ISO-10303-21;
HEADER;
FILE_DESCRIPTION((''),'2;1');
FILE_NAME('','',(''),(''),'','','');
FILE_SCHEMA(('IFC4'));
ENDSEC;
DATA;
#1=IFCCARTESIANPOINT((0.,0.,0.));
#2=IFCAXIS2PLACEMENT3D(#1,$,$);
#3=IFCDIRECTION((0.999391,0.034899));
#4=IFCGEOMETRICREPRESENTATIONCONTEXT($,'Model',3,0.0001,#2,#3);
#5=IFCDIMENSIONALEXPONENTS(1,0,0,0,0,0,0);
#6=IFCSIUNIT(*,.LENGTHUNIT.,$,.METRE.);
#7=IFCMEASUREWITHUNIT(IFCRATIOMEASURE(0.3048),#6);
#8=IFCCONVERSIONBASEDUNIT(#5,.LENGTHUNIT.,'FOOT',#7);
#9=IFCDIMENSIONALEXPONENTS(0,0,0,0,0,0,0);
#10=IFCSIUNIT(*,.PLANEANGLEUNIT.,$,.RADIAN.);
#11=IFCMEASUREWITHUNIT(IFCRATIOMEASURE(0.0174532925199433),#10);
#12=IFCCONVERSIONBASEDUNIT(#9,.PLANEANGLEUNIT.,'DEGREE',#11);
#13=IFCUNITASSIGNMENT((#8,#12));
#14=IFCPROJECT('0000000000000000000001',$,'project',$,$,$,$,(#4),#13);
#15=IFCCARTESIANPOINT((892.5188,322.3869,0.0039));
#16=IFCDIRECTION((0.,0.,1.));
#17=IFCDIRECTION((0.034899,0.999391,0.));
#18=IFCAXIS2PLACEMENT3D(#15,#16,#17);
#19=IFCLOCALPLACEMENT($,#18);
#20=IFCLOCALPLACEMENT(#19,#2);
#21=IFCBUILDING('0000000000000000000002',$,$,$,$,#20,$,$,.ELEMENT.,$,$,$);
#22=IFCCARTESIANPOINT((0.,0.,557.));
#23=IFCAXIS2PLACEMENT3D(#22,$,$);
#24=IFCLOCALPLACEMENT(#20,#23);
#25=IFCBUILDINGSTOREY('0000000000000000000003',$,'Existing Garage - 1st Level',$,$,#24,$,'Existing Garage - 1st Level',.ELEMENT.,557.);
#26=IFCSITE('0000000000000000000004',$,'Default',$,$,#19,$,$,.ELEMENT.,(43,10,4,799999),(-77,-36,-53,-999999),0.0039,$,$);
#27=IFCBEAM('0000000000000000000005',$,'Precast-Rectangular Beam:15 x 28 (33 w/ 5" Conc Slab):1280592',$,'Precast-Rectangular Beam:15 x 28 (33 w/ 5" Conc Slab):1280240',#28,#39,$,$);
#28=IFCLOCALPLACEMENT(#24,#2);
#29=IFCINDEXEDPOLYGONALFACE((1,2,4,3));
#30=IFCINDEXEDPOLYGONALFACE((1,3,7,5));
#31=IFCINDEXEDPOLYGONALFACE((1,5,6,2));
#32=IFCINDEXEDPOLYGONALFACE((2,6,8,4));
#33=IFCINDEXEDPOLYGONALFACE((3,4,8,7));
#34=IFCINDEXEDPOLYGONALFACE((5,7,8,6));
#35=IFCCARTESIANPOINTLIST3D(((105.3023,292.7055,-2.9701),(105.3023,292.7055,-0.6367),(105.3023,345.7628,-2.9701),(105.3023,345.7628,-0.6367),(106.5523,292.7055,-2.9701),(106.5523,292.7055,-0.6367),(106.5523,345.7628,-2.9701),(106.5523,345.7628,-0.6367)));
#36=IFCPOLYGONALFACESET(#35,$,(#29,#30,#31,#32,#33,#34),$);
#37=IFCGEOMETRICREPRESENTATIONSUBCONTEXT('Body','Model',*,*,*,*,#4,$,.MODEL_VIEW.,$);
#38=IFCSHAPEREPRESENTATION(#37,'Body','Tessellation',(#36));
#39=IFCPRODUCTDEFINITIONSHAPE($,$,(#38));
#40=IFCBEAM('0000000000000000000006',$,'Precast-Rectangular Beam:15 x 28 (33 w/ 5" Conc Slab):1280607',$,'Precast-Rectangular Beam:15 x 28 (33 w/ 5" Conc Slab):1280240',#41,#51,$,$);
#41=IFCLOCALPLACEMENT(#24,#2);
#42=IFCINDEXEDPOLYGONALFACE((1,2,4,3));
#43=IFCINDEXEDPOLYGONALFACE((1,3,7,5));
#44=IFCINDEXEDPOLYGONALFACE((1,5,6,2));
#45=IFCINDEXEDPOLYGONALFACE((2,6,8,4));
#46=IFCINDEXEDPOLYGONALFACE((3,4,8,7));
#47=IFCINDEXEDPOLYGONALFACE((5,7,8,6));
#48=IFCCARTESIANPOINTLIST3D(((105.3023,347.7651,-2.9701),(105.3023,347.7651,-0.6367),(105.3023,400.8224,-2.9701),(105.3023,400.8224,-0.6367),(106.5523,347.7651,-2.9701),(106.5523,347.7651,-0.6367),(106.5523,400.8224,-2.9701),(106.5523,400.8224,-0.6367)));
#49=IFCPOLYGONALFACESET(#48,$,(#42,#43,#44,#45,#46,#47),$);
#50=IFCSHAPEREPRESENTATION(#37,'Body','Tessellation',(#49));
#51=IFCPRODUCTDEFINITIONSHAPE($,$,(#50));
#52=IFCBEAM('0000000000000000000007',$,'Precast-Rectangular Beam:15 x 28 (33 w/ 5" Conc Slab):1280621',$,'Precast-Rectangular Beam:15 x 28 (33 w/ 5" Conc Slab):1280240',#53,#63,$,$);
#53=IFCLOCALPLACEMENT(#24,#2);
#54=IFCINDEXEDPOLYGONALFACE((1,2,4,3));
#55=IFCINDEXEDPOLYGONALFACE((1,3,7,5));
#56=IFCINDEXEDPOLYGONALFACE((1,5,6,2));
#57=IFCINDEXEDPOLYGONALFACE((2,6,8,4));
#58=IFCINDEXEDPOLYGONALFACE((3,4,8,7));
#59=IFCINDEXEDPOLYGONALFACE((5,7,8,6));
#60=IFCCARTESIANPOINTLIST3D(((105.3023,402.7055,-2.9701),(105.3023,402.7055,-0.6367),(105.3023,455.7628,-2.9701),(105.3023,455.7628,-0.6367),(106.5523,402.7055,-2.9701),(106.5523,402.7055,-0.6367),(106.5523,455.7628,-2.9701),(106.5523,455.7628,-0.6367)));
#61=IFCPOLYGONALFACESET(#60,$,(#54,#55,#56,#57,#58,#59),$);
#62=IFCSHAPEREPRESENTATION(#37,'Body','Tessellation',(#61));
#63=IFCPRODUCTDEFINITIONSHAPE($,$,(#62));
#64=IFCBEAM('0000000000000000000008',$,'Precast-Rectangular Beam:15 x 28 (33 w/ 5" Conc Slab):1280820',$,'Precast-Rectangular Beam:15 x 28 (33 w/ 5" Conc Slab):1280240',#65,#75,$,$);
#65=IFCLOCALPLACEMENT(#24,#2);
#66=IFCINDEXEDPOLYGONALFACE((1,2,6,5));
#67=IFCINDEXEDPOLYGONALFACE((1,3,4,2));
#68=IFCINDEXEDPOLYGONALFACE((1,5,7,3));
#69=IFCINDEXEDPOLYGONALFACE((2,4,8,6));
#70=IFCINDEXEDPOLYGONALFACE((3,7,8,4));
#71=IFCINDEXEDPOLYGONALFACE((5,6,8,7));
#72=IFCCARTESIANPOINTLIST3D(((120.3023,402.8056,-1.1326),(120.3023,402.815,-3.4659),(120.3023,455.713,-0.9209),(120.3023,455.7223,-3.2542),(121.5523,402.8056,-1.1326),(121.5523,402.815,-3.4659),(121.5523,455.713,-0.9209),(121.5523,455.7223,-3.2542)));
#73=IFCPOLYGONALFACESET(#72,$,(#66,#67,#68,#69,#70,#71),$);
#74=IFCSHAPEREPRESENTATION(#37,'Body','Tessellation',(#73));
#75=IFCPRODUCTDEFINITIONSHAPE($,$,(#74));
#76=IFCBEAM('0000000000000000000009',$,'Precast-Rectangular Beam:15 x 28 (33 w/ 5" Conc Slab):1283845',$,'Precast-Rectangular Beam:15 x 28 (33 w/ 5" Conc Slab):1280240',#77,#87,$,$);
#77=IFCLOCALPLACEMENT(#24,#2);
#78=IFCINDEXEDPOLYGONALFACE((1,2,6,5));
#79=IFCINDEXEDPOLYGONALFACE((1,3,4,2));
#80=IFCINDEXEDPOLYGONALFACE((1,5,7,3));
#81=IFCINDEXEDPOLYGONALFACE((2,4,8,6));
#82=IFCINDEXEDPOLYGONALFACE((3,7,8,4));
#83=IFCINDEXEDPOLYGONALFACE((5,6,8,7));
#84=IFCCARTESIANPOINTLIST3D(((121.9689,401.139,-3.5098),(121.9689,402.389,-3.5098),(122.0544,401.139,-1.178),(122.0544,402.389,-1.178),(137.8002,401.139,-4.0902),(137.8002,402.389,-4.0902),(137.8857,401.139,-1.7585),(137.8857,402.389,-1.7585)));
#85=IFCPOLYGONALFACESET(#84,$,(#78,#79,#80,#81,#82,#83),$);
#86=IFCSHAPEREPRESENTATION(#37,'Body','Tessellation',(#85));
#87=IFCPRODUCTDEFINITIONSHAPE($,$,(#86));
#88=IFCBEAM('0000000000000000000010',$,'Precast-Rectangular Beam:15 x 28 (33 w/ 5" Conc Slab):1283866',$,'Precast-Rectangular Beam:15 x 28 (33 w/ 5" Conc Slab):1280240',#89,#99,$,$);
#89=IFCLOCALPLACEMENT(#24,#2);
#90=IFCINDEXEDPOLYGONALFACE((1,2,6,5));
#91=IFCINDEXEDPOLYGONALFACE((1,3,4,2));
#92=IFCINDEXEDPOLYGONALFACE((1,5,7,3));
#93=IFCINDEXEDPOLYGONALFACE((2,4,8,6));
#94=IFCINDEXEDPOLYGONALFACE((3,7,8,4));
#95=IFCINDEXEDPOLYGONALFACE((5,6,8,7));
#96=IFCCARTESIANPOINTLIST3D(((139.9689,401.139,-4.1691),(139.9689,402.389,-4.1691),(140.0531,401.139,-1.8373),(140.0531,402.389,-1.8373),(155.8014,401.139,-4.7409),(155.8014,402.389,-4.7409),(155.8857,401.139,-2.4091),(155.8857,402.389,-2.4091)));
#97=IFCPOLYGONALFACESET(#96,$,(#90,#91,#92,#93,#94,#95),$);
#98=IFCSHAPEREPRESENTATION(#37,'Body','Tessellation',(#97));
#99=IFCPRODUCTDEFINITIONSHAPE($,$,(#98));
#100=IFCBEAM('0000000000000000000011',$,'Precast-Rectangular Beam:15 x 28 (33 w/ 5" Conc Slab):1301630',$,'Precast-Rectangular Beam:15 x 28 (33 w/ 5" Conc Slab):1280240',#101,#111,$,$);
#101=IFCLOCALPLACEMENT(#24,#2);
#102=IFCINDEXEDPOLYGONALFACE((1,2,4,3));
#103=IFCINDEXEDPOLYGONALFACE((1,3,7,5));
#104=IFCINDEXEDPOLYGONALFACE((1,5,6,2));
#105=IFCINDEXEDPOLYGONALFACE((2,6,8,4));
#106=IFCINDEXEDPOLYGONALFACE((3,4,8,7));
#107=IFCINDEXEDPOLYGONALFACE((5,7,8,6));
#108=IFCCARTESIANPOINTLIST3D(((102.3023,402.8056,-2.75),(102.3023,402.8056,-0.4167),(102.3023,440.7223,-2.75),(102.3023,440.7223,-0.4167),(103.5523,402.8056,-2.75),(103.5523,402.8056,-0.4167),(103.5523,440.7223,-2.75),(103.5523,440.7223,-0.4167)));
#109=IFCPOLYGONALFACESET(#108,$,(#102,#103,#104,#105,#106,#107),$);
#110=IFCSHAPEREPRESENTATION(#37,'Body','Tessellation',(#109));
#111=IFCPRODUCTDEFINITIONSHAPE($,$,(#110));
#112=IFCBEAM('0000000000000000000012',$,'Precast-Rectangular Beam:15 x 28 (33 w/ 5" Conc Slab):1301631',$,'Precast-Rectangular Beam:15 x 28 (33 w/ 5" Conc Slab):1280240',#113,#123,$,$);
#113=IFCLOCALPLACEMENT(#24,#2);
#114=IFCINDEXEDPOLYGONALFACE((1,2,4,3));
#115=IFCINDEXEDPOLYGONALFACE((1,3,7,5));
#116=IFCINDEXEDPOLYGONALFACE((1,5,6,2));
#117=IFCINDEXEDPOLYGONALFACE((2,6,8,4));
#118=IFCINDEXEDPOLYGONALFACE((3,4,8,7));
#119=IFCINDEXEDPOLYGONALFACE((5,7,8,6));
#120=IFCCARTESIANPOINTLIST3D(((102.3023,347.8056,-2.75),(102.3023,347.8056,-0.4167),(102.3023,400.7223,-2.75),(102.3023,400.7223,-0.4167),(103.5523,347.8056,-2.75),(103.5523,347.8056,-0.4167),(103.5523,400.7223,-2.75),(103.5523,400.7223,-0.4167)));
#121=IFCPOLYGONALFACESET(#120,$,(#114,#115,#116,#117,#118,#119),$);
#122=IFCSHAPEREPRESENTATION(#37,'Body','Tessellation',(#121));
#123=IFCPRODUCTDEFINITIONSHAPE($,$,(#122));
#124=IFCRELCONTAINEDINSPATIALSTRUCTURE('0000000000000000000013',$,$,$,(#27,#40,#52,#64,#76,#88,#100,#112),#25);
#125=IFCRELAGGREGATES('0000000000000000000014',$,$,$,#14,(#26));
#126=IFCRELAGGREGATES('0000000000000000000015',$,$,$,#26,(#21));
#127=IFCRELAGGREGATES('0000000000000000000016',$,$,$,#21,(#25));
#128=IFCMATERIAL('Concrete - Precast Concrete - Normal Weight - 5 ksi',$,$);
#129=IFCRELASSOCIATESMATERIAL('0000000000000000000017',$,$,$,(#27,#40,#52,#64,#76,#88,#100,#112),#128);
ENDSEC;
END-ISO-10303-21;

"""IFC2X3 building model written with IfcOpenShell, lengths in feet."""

from ifc_helpers import new_model, entity, si_unit, converted_unit, direction, frame, frame_2d, origin, place, context, subcontext, project, spatial, rectangle, extrude, material, element, save


model = new_model("IFC2X3")

# Units and contexts
model_context = context("Model", 3, precision=0.0001, world=origin(), true_north=direction((0.999391, 0.034899)))
body_context = subcontext(model_context, "Body", "Model", "MODEL_VIEW")
ifc_project = project(units=[converted_unit("LENGTHUNIT", "FOOT", entity("IfcRatioMeasure", 0.3048), si_unit("LENGTHUNIT", "METRE"), dimensions=[1, 0, 0, 0, 0, 0, 0]), converted_unit("PLANEANGLEUNIT", "DEGREE", entity("IfcRatioMeasure", 0.0174532925199433), si_unit("PLANEANGLEUNIT", "RADIAN"), dimensions=[0, 0, 0, 0, 0, 0, 0])], contexts=[model_context])

# Site, building, storey
site_placement = place(None, frame((892.5188, 322.3869, 0.0039), z_axis=(0.0, 0.0, 1.0), x_axis=(0.034899, 0.999391, 0.0)))
site = spatial("IfcSite", under=ifc_project, at=site_placement, Name="Default", CompositionType="ELEMENT", RefLatitude=(43, 10, 4, 799999), RefLongitude=(-77, -36, -53, -999999), RefElevation=0.0039)
building_placement = place(site_placement, origin())
building = spatial("IfcBuilding", under=site, at=building_placement, CompositionType="ELEMENT")
storey_placement = place(building_placement, frame((0.0, 0.0, 557.0)))
storey = spatial("IfcBuildingStorey", under=building, at=storey_placement, Name="Existing Garage - 1st Level", LongName="Existing Garage - 1st Level", CompositionType="ELEMENT", Elevation=557.0)

# Beams
ifc_material_1 = material(Name="Concrete - Precast Concrete - Normal Weight - 5 ksi")
beam_1_placement = place(storey_placement, frame((105.9273, 346.764, -0.6367), z_axis=(0.0, 0.0, 1.0), x_axis=(0.0, -1.0, 0.0)))
element("IfcBeam", 1, at=beam_1_placement, inside=storey, material=ifc_material_1, Name="Precast-Rectangular Beam:15 x 28 (33 w/ 5\" Conc Slab):1280592", ObjectType="Precast-Rectangular Beam:15 x 28 (33 w/ 5\" Conc Slab):1280240", context=body_context, shape_type="SweptSolid", body=[
    extrude(rectangle(XDim=2.3333, YDim=1.25, at=frame_2d((0.0, 0.0), x_axis=(1.0, 0.0))), frame((1.0012, 0.0, -1.1667), z_axis=(1.0, 0.0, 0.0), x_axis=(0.0, 0.0, -1.0)), (0.0, 0.0, 1.0), 53.0573),
])
beam_2_placement = place(storey_placement, frame((105.9273, 346.764, -0.6367), z_axis=(0.0, 0.0, 1.0), x_axis=(0.0, 1.0, 0.0)))
element("IfcBeam", 2, at=beam_2_placement, inside=storey, material=ifc_material_1, Name="Precast-Rectangular Beam:15 x 28 (33 w/ 5\" Conc Slab):1280607", ObjectType="Precast-Rectangular Beam:15 x 28 (33 w/ 5\" Conc Slab):1280240", context=body_context, shape_type="SweptSolid", body=[
    extrude(rectangle(XDim=2.3333, YDim=1.25, at=frame_2d((0.0, 0.0), x_axis=(1.0, 0.0))), frame((1.0012, 0.0, -1.1667), z_axis=(1.0, 0.0, 0.0), x_axis=(0.0, 0.0, -1.0)), (0.0, 0.0, 1.0), 53.0573),
])
beam_3_placement = place(storey_placement, frame((105.9273, 456.764, -0.6367), z_axis=(0.0, 0.0, 1.0), x_axis=(0.0, -1.0, 0.0)))
element("IfcBeam", 3, at=beam_3_placement, inside=storey, material=ifc_material_1, Name="Precast-Rectangular Beam:15 x 28 (33 w/ 5\" Conc Slab):1280621", ObjectType="Precast-Rectangular Beam:15 x 28 (33 w/ 5\" Conc Slab):1280240", context=body_context, shape_type="SweptSolid", body=[
    extrude(rectangle(XDim=2.3333, YDim=1.25, at=frame_2d((0.0, 0.0), x_axis=(1.0, 0.0))), frame((1.0012, 0.0, -1.1667), z_axis=(1.0, 0.0, 0.0), x_axis=(0.0, 0.0, -1.0)), (0.0, 0.0, 1.0), 53.0573),
])
beam_4_placement = place(storey_placement, frame((120.9273, 456.764, -0.9167), z_axis=(0.0, -0.004001, 0.999992), x_axis=(0.0, -0.999992, -0.004001)))
element("IfcBeam", 4, at=beam_4_placement, inside=storey, material=ifc_material_1, Name="Precast-Rectangular Beam:15 x 28 (33 w/ 5\" Conc Slab):1280820", ObjectType="Precast-Rectangular Beam:15 x 28 (33 w/ 5\" Conc Slab):1280240", context=body_context, shape_type="SweptSolid", body=[
    extrude(rectangle(XDim=2.3333, YDim=1.25, at=frame_2d((0.0, 0.0), x_axis=(1.0, 0.0))), frame((1.051, 0.0, -1.1667), z_axis=(1.0, 0.0, 0.0), x_axis=(0.0, 0.0, -1.0)), (0.0, 0.0, 1.0), 52.9078),
])
beam_5_placement = place(storey_placement, frame((120.9273, 401.764, -1.1367), z_axis=(0.036642, 0.0, 0.999328), x_axis=(0.999328, 0.0, -0.036642)))
element("IfcBeam", 5, at=beam_5_placement, inside=storey, material=ifc_material_1, Name="Precast-Rectangular Beam:15 x 28 (33 w/ 5\" Conc Slab):1283845", ObjectType="Precast-Rectangular Beam:15 x 28 (33 w/ 5\" Conc Slab):1280240", context=body_context, shape_type="SweptSolid", body=[
    extrude(rectangle(XDim=2.3333, YDim=1.25, at=frame_2d((0.0, 0.0), x_axis=(1.0, 0.0))), frame((1.1279, 0.0, -1.1667), z_axis=(1.0, 0.0, 0.0), x_axis=(0.0, 0.0, -1.0)), (0.0, 0.0, 1.0), 15.8419),
])
beam_6_placement = place(storey_placement, frame((138.9273, 401.764, -1.7967), z_axis=(0.036088, 0.0, 0.999349), x_axis=(0.999349, 0.0, -0.036088)))
element("IfcBeam", 6, at=beam_6_placement, inside=storey, material=ifc_material_1, Name="Precast-Rectangular Beam:15 x 28 (33 w/ 5\" Conc Slab):1283866", ObjectType="Precast-Rectangular Beam:15 x 28 (33 w/ 5\" Conc Slab):1280240", context=body_context, shape_type="SweptSolid", body=[
    extrude(rectangle(XDim=2.3333, YDim=1.25, at=frame_2d((0.0, 0.0), x_axis=(1.0, 0.0))), frame((1.1266, 0.0, -1.1667), z_axis=(1.0, 0.0, 0.0), x_axis=(0.0, 0.0, -1.0)), (0.0, 0.0, 1.0), 15.8428),
])
beam_7_placement = place(storey_placement, frame((102.9273, 441.7647, -0.4167), z_axis=(0.0, 0.0, 1.0), x_axis=(0.0, -1.0, 0.0)))
element("IfcBeam", 7, at=beam_7_placement, inside=storey, material=ifc_material_1, Name="Precast-Rectangular Beam:15 x 28 (33 w/ 5\" Conc Slab):1301630", ObjectType="Precast-Rectangular Beam:15 x 28 (33 w/ 5\" Conc Slab):1280240", context=body_context, shape_type="SweptSolid", body=[
    extrude(rectangle(XDim=2.3333, YDim=1.25, at=frame_2d((0.0, 0.0), x_axis=(1.0, 0.0))), frame((1.0424, 0.0, -1.1667), z_axis=(1.0, 0.0, 0.0), x_axis=(0.0, 0.0, -1.0)), (0.0, 0.0, 1.0), 37.9167),
])
beam_8_placement = place(storey_placement, frame((102.9273, 401.764, -0.4167), z_axis=(0.0, 0.0, 1.0), x_axis=(0.0, -1.0, 0.0)))
element("IfcBeam", 8, at=beam_8_placement, inside=storey, material=ifc_material_1, Name="Precast-Rectangular Beam:15 x 28 (33 w/ 5\" Conc Slab):1301631", ObjectType="Precast-Rectangular Beam:15 x 28 (33 w/ 5\" Conc Slab):1280240", context=body_context, shape_type="SweptSolid", body=[
    extrude(rectangle(XDim=2.3333, YDim=1.25, at=frame_2d((0.0, 0.0), x_axis=(1.0, 0.0))), frame((1.0417, 0.0, -1.1667), z_axis=(1.0, 0.0, 0.0), x_axis=(0.0, 0.0, -1.0)), (0.0, 0.0, 1.0), 52.9167),
])

save(model, "model.ifc")
